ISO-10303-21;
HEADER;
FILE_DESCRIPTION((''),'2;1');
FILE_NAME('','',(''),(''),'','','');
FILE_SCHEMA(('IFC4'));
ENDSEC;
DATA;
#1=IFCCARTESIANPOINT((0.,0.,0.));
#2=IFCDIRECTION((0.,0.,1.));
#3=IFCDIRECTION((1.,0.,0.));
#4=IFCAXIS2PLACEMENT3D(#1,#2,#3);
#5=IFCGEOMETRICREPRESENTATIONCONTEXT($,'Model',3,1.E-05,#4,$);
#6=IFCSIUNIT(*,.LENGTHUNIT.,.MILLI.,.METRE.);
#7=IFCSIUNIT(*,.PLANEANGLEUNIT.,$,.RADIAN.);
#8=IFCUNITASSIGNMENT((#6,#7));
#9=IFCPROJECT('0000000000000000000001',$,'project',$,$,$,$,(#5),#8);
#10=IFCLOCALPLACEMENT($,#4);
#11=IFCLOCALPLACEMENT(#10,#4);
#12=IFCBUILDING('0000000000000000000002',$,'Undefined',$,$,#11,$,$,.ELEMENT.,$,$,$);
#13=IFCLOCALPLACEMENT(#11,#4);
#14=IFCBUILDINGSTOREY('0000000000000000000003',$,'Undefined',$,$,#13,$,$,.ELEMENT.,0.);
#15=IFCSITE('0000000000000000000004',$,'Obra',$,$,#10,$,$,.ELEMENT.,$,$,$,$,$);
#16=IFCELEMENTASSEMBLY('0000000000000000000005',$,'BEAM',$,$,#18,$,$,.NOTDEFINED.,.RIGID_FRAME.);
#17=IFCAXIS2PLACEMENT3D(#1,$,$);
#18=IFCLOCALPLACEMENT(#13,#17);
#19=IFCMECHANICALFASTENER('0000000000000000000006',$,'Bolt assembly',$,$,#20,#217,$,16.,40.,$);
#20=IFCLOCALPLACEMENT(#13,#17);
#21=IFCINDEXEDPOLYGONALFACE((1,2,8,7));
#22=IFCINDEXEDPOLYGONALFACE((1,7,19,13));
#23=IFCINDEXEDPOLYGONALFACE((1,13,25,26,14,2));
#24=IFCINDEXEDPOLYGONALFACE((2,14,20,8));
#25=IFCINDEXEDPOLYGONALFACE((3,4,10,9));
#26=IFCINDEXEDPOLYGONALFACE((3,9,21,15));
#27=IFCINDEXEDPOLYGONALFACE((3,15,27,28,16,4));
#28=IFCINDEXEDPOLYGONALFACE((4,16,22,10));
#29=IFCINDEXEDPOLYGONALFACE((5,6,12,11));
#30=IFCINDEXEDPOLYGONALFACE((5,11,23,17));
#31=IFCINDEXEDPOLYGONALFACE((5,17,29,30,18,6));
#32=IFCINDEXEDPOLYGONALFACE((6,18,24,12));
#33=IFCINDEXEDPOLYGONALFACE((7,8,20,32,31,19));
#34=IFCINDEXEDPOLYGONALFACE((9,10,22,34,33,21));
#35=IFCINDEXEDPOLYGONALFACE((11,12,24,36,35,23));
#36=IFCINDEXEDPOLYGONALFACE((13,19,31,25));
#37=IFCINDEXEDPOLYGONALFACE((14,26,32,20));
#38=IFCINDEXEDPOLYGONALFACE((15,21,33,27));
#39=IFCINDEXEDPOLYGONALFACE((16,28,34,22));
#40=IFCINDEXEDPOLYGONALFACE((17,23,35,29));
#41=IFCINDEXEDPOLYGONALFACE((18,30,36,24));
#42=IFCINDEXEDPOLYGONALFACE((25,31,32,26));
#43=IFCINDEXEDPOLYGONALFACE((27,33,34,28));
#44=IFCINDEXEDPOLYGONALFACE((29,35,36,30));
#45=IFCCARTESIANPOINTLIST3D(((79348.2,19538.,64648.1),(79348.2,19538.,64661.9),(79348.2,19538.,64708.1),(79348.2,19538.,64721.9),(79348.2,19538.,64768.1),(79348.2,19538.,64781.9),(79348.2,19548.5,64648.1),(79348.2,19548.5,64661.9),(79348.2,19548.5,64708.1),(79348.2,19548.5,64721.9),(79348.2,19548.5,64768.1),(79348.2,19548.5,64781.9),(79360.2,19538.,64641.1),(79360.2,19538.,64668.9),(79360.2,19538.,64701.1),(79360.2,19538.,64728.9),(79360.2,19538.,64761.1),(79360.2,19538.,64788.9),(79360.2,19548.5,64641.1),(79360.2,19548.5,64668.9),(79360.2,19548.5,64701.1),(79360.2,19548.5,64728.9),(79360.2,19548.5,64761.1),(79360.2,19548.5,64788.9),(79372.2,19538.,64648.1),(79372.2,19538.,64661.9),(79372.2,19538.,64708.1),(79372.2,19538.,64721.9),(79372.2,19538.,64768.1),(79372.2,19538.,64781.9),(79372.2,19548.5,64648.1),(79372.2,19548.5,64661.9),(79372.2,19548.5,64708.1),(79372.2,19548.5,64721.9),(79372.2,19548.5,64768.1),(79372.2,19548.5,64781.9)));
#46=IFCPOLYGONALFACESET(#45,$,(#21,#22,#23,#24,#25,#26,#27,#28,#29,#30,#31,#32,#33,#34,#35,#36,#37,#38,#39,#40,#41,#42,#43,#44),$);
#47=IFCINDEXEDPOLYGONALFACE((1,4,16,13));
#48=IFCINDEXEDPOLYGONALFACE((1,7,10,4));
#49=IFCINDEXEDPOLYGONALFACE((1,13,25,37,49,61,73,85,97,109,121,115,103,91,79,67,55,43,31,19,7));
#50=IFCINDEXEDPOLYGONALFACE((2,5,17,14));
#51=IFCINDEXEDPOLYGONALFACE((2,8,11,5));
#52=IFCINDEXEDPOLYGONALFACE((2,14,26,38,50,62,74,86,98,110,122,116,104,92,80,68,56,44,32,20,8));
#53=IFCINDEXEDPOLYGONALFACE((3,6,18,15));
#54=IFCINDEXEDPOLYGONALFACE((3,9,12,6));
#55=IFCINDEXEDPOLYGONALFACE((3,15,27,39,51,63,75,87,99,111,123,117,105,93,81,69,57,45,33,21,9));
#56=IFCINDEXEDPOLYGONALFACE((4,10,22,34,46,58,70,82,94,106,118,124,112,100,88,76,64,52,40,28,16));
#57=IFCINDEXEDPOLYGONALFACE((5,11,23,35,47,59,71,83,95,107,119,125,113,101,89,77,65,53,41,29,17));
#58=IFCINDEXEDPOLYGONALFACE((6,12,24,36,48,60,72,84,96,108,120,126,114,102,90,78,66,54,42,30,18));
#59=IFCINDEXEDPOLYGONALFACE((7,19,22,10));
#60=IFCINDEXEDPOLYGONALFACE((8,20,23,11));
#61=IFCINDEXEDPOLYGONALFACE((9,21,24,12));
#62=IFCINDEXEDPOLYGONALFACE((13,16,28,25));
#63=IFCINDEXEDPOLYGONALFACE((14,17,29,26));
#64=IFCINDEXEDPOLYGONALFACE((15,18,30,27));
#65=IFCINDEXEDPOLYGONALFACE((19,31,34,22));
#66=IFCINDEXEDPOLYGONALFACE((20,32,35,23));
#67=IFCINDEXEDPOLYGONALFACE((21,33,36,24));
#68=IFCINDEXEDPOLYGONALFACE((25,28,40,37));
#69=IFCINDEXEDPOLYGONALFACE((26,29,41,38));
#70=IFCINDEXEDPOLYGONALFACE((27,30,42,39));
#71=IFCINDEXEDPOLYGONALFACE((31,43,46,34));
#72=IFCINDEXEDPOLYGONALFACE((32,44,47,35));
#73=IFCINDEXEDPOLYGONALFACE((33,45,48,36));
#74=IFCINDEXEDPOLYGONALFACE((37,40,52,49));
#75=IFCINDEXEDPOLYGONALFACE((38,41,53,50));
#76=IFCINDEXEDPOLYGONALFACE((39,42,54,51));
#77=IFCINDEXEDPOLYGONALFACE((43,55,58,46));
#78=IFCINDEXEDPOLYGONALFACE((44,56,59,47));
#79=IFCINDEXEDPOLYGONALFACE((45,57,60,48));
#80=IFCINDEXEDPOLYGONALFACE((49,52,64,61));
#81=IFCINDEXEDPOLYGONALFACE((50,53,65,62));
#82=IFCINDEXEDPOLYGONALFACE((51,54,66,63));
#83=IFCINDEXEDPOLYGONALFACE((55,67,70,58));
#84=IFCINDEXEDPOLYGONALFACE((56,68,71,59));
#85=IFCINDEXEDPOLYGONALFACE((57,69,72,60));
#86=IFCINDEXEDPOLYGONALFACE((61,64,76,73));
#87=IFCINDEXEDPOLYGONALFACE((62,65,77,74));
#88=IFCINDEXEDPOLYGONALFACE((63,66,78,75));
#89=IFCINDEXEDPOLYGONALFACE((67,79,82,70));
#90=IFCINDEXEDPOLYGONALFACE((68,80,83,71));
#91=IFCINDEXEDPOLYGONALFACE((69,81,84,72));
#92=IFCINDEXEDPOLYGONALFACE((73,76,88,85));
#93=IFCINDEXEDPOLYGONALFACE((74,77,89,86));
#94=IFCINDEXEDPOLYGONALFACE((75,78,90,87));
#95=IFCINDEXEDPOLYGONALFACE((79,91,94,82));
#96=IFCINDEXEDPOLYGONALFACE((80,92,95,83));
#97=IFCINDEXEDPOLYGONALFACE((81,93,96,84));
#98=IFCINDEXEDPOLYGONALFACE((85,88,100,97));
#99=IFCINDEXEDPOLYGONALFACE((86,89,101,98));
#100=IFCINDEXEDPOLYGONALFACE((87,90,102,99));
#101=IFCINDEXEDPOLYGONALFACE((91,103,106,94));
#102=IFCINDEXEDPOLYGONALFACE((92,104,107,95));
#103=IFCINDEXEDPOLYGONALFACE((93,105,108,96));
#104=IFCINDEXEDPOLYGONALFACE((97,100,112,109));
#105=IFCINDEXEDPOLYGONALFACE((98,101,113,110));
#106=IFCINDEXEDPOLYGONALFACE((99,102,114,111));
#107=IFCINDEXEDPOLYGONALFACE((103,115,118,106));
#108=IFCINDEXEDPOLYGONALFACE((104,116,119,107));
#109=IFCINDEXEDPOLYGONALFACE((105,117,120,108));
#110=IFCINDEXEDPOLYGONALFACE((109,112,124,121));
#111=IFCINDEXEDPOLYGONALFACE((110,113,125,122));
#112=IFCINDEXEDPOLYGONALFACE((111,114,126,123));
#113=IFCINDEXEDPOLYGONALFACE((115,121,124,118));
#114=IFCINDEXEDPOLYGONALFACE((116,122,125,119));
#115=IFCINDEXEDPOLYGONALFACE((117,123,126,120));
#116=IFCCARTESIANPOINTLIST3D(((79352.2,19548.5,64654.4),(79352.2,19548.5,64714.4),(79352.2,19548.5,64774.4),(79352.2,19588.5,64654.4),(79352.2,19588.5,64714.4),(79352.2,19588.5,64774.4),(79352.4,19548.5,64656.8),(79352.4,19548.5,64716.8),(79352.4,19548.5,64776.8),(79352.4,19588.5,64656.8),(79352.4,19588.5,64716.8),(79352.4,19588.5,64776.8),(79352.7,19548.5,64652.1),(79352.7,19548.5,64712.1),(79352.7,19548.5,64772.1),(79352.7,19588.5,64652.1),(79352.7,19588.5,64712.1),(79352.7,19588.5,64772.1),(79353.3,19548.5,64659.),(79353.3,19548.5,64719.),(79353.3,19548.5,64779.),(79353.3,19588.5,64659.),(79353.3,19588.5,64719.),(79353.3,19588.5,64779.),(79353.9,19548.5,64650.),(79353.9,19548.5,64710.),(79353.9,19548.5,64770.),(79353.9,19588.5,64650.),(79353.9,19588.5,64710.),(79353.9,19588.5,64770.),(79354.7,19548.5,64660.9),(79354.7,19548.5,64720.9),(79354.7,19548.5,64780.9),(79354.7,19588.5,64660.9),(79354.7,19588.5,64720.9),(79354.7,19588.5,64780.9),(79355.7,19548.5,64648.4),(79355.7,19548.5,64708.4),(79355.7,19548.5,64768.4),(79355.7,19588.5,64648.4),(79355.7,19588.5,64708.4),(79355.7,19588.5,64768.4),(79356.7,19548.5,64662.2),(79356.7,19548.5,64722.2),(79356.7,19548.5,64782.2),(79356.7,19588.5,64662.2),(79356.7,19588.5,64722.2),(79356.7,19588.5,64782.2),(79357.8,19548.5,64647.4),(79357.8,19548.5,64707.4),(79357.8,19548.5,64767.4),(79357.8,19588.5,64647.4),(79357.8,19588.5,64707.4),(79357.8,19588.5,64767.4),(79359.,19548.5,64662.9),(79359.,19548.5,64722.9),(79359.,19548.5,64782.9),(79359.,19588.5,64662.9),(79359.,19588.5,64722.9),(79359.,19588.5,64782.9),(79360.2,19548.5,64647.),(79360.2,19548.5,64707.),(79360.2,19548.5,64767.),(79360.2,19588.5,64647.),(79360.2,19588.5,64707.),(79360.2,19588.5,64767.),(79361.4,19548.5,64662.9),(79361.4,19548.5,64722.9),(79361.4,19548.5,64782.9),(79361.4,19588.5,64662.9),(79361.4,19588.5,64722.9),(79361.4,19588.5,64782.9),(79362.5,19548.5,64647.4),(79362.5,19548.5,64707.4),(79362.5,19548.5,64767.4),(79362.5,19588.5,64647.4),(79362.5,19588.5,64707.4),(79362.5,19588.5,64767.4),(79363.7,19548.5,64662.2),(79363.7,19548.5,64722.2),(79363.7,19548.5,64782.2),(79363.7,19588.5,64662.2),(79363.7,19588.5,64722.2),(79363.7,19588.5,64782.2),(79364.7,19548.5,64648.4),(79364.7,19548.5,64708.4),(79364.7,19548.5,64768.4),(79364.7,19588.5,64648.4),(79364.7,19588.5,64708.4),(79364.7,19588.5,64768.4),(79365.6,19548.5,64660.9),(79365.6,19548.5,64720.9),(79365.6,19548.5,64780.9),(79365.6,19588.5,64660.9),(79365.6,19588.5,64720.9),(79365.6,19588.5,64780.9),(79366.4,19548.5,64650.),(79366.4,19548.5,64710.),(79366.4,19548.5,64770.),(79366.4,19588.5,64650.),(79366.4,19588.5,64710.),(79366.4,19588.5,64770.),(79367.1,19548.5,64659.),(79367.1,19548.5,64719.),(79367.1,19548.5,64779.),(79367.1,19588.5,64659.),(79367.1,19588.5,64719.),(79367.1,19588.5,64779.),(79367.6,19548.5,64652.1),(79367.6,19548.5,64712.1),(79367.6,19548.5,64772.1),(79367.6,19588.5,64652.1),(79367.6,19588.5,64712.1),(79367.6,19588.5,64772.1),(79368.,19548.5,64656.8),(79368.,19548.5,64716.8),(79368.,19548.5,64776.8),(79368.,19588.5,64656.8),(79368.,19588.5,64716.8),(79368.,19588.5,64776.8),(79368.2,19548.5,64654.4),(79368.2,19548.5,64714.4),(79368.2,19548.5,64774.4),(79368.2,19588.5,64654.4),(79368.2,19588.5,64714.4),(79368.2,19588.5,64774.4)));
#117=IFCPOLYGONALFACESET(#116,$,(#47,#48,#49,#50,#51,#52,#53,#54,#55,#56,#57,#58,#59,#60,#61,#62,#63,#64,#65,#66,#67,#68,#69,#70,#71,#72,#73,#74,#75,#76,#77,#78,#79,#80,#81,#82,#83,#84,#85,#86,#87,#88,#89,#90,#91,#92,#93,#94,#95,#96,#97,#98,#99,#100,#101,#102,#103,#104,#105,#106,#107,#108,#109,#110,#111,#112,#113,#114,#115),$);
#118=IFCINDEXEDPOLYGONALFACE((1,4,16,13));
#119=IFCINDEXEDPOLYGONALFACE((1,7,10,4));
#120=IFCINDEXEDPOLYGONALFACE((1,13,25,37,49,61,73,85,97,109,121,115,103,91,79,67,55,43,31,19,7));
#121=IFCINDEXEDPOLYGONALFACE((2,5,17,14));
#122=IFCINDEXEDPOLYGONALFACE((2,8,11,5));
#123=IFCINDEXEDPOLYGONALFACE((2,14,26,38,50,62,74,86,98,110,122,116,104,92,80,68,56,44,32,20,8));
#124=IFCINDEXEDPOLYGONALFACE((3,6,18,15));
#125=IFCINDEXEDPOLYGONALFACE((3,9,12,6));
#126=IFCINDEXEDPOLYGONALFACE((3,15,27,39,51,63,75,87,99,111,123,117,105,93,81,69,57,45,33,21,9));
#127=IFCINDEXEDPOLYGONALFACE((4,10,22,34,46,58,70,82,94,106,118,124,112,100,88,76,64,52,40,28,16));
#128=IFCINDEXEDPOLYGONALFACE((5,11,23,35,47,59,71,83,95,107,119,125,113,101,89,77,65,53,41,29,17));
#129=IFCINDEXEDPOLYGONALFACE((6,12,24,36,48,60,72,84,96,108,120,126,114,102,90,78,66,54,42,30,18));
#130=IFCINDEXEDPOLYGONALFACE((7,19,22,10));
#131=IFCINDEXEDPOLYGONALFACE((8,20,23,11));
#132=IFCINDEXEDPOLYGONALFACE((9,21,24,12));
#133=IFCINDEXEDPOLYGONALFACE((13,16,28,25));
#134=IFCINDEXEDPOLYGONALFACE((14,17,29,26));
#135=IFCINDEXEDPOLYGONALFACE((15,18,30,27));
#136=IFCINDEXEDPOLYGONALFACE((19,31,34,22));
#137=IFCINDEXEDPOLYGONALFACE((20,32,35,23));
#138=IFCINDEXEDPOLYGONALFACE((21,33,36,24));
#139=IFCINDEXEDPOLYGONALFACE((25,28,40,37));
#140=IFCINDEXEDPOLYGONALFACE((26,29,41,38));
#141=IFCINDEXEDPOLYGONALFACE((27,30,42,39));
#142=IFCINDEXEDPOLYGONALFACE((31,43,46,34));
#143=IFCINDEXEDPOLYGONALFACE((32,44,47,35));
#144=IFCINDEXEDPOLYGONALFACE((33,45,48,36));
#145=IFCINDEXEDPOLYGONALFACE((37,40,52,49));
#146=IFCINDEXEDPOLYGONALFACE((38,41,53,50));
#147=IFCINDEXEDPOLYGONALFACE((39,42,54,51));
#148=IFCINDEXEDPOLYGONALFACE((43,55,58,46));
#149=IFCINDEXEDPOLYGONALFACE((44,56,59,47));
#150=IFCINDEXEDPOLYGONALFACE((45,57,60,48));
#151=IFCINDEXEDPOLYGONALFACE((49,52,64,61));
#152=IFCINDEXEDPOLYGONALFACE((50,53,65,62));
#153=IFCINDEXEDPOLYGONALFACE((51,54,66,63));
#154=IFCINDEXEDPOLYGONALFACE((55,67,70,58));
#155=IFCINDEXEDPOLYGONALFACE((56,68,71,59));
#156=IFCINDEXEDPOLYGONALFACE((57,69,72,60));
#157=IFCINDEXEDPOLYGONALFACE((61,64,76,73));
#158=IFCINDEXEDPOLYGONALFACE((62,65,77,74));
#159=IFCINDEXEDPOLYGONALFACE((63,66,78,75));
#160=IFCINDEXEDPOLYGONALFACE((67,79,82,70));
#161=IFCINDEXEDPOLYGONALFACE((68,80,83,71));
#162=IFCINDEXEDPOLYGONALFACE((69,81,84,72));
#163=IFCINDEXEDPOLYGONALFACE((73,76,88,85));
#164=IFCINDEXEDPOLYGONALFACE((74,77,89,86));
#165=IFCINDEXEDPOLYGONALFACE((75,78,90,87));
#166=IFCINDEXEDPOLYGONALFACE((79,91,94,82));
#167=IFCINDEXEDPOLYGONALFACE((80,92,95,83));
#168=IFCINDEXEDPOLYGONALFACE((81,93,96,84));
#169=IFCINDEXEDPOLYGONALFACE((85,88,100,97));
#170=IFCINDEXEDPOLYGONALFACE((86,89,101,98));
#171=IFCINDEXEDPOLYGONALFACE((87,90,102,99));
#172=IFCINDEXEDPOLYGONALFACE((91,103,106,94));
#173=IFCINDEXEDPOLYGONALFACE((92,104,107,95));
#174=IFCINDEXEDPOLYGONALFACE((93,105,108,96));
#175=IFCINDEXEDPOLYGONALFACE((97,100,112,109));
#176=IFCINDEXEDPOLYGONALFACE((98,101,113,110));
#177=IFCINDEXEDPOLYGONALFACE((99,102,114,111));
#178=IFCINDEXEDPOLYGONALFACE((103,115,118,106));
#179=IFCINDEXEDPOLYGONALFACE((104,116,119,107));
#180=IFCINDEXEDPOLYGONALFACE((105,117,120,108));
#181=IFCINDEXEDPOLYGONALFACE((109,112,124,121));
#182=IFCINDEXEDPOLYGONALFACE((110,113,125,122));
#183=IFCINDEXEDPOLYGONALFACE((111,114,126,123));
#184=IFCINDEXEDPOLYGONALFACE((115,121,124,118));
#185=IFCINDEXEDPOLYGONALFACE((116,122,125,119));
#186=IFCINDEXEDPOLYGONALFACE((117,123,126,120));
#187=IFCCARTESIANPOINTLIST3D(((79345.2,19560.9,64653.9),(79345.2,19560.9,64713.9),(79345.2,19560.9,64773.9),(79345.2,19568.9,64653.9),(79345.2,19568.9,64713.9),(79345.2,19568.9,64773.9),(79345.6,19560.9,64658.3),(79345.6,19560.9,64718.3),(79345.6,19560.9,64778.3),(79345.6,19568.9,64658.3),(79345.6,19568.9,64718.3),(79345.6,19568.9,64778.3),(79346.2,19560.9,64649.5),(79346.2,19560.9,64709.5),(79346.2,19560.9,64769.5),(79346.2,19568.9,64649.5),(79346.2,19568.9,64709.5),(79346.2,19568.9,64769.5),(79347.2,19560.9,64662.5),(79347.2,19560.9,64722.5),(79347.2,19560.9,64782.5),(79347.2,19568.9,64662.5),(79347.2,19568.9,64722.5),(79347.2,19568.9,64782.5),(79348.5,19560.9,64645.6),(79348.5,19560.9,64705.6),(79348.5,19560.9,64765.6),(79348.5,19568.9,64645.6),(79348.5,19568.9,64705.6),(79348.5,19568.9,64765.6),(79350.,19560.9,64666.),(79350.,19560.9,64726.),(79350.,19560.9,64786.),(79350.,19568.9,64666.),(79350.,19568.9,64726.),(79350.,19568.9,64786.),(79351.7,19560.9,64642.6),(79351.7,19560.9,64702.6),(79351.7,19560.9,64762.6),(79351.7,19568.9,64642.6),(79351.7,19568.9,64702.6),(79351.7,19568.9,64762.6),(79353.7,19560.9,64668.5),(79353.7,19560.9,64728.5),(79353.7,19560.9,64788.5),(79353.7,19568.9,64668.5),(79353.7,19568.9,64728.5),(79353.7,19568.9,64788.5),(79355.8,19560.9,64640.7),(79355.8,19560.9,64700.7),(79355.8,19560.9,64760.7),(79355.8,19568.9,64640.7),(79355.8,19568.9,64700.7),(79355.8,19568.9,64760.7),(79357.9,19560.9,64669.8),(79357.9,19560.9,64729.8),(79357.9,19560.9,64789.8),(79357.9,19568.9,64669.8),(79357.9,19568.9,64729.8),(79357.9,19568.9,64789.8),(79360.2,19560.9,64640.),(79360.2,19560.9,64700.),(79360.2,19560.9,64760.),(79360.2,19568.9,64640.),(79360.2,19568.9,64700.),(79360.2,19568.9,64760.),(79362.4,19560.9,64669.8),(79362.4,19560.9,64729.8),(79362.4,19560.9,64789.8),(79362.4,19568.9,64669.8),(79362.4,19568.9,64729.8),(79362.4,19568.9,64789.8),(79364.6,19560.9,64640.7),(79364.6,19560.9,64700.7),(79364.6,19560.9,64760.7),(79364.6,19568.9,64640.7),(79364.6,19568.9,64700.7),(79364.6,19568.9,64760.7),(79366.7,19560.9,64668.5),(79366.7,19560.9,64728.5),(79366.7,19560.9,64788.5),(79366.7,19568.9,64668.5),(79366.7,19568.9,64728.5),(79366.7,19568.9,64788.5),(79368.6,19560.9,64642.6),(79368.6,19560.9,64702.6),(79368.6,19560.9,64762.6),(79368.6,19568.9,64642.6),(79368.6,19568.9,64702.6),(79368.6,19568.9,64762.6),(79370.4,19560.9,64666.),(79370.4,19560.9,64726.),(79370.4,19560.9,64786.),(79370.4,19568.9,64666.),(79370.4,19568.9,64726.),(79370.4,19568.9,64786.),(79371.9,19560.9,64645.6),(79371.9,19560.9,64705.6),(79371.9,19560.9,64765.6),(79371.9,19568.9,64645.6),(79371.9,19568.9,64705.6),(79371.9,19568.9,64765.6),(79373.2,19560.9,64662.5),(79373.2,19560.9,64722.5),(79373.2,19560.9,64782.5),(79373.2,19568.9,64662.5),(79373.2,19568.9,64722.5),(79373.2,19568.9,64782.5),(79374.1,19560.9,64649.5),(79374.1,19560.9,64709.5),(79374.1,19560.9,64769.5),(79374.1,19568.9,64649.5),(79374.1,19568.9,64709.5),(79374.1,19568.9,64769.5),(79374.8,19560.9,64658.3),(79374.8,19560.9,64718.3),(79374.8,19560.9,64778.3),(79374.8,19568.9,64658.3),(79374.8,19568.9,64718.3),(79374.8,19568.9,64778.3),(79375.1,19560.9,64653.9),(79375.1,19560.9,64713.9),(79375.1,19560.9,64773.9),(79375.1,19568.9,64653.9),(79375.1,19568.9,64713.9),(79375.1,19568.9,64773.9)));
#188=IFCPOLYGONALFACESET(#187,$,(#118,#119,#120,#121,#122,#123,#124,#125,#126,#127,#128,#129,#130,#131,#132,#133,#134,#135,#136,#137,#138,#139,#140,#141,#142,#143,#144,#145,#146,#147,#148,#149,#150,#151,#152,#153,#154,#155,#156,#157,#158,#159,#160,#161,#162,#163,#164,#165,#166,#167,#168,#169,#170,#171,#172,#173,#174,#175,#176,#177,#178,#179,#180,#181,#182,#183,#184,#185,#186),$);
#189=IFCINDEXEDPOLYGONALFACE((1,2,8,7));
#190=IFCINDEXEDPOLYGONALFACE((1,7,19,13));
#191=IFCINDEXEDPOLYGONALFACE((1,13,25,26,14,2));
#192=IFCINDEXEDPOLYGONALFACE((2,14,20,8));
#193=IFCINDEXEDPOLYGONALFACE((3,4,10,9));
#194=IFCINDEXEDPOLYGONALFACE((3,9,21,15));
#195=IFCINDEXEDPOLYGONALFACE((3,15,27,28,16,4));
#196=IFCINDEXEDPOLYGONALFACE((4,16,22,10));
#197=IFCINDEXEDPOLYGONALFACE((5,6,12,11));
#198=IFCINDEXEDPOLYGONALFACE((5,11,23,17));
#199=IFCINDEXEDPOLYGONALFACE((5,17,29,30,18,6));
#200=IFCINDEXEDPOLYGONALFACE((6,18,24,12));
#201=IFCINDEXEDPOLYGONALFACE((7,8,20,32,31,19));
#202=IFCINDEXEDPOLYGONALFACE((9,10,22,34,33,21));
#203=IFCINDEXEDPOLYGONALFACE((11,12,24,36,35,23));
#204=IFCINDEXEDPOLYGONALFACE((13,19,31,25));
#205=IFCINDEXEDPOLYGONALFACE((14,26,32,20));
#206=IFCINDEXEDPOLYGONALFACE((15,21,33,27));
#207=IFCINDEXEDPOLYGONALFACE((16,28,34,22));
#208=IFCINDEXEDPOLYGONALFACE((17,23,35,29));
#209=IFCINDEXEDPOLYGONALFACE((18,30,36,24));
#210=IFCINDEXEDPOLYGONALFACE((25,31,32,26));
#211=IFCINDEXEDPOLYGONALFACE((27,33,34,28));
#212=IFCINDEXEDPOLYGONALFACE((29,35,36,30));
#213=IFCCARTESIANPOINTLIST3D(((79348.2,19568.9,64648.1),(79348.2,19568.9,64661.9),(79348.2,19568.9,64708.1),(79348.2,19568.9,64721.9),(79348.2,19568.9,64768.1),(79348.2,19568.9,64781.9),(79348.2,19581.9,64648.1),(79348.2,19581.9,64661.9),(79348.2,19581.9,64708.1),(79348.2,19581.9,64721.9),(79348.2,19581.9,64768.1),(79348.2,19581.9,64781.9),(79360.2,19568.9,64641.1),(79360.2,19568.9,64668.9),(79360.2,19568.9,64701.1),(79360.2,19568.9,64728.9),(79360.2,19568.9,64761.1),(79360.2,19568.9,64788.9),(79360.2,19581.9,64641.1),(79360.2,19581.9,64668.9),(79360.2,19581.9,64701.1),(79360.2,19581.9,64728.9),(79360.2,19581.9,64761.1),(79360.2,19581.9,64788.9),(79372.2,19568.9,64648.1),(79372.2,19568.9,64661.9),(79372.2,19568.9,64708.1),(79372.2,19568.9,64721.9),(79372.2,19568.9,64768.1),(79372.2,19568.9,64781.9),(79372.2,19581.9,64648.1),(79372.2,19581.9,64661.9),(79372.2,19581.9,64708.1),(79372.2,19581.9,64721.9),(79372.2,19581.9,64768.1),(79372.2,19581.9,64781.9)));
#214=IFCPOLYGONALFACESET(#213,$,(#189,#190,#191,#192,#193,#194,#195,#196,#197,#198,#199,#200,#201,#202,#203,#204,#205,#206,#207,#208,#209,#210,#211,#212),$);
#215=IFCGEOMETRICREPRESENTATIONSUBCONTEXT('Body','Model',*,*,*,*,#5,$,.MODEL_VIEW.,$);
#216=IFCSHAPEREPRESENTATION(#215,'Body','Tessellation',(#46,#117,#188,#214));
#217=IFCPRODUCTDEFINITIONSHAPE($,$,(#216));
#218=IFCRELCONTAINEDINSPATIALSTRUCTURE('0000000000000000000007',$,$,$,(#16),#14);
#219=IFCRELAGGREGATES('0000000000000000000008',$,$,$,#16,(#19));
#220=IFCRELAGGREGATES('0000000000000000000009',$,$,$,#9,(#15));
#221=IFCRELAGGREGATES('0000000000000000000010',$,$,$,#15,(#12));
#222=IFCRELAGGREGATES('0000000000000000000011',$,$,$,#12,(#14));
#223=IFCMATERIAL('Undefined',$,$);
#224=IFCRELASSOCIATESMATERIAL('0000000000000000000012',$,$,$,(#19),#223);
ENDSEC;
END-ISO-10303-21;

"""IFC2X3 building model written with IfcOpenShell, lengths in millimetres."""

from ifc_helpers import new_model, si_unit, frame, origin_with_axes, origin_2d_with_axis, place, context, subcontext, project, spatial, polyline, circle, outline, extrude, source, transform, mapped, material, element, aggregate, save


model = new_model("IFC2X3")

# Units and contexts
model_context = context("Model", 3, precision=1e-05, world=origin_with_axes())
body_context = subcontext(model_context, "Body", "Model", "MODEL_VIEW")
ifc_project = project(units=[si_unit("LENGTHUNIT", "METRE", prefix="MILLI"), si_unit("PLANEANGLEUNIT", "RADIAN")], contexts=[model_context])

# Site, building, storey
site_placement = place(None, origin_with_axes())
site = spatial("IfcSite", under=ifc_project, at=site_placement, Name="Obra", CompositionType="ELEMENT")
building_placement = place(site_placement, origin_with_axes())
building = spatial("IfcBuilding", under=site, at=building_placement, Name="Undefined", CompositionType="ELEMENT")
storey_placement = place(building_placement, origin_with_axes())
storey = spatial("IfcBuildingStorey", under=building, at=storey_placement, Name="Undefined", CompositionType="ELEMENT", Elevation=0.0)

# Element assembly, mechanical fastener
ifc_material_1 = material(Name="Undefined")
assembly_1_placement = place(storey_placement, origin_with_axes())
assembly_1 = element("IfcElementAssembly", 1, at=assembly_1_placement, inside=storey, Name="BEAM", AssemblyPlace="NOTDEFINED", PredefinedType="RIGID_FRAME")
shared_shape_1 = source(origin_with_axes(), body_context, "Body", "SweptSolid", [
    extrude(outline(polyline([(13.9, 0.0), (6.9, 12.0), (-6.9, 12.0), (-13.9, 0.0), (-6.9, -12.0), (6.9, -12.0), (13.9, 0.0)])), frame((0.0, -19.7, 0.0), z_axis=(0.0, 1.0, 0.0), x_axis=(1.0, 0.0, 0.0)), (0.0, 0.0, 1.0), 10.6),
    extrude(circle(Radius=8.0, at=origin_2d_with_axis()), frame((0.0, -9.1, 0.0), z_axis=(0.0, 1.0, 0.0), x_axis=(1.0, 0.0, 0.0)), (0.0, 0.0, 1.0), 40.0),
    extrude(circle(Radius=15.0, at=origin_2d_with_axis()), frame((0.0, 3.3, 0.0), z_axis=(0.0, 1.0, 0.0), x_axis=(1.0, 0.0, 0.0)), (0.0, 0.0, 1.0), 8.0),
    extrude(outline(polyline([(13.9, 0.0), (6.9, 12.0), (-6.9, 12.0), (-13.9, 0.0), (-6.9, -12.0), (6.9, -12.0), (13.9, 0.0)])), frame((0.0, 11.3, 0.0), z_axis=(0.0, 1.0, 0.0), x_axis=(1.0, 0.0, 0.0)), (0.0, 0.0, 1.0), 13.0),
])
mechanical_fastener_1_placement = place(assembly_1_placement, frame((79310.2, 19557.6, 64835.0), z_axis=(1.0, 0.0, 0.0), x_axis=(0.0, 0.0, -1.0)))
mechanical_fastener_1 = element("IfcMechanicalFastener", 2, at=mechanical_fastener_1_placement, material=ifc_material_1, Name="Bolt assembly", NominalDiameter=16.0, NominalLength=40.0, context=body_context, shape_type="MappedRepresentation", body=[
    mapped(shared_shape_1, transform((60.0, 0.0, 50.0))),
    mapped(shared_shape_1, transform((120.0, 0.0, 50.0))),
    mapped(shared_shape_1, transform((180.0, 0.0, 50.0))),
])
aggregate(assembly_1, [mechanical_fastener_1])

save(model, "model.ifc")
